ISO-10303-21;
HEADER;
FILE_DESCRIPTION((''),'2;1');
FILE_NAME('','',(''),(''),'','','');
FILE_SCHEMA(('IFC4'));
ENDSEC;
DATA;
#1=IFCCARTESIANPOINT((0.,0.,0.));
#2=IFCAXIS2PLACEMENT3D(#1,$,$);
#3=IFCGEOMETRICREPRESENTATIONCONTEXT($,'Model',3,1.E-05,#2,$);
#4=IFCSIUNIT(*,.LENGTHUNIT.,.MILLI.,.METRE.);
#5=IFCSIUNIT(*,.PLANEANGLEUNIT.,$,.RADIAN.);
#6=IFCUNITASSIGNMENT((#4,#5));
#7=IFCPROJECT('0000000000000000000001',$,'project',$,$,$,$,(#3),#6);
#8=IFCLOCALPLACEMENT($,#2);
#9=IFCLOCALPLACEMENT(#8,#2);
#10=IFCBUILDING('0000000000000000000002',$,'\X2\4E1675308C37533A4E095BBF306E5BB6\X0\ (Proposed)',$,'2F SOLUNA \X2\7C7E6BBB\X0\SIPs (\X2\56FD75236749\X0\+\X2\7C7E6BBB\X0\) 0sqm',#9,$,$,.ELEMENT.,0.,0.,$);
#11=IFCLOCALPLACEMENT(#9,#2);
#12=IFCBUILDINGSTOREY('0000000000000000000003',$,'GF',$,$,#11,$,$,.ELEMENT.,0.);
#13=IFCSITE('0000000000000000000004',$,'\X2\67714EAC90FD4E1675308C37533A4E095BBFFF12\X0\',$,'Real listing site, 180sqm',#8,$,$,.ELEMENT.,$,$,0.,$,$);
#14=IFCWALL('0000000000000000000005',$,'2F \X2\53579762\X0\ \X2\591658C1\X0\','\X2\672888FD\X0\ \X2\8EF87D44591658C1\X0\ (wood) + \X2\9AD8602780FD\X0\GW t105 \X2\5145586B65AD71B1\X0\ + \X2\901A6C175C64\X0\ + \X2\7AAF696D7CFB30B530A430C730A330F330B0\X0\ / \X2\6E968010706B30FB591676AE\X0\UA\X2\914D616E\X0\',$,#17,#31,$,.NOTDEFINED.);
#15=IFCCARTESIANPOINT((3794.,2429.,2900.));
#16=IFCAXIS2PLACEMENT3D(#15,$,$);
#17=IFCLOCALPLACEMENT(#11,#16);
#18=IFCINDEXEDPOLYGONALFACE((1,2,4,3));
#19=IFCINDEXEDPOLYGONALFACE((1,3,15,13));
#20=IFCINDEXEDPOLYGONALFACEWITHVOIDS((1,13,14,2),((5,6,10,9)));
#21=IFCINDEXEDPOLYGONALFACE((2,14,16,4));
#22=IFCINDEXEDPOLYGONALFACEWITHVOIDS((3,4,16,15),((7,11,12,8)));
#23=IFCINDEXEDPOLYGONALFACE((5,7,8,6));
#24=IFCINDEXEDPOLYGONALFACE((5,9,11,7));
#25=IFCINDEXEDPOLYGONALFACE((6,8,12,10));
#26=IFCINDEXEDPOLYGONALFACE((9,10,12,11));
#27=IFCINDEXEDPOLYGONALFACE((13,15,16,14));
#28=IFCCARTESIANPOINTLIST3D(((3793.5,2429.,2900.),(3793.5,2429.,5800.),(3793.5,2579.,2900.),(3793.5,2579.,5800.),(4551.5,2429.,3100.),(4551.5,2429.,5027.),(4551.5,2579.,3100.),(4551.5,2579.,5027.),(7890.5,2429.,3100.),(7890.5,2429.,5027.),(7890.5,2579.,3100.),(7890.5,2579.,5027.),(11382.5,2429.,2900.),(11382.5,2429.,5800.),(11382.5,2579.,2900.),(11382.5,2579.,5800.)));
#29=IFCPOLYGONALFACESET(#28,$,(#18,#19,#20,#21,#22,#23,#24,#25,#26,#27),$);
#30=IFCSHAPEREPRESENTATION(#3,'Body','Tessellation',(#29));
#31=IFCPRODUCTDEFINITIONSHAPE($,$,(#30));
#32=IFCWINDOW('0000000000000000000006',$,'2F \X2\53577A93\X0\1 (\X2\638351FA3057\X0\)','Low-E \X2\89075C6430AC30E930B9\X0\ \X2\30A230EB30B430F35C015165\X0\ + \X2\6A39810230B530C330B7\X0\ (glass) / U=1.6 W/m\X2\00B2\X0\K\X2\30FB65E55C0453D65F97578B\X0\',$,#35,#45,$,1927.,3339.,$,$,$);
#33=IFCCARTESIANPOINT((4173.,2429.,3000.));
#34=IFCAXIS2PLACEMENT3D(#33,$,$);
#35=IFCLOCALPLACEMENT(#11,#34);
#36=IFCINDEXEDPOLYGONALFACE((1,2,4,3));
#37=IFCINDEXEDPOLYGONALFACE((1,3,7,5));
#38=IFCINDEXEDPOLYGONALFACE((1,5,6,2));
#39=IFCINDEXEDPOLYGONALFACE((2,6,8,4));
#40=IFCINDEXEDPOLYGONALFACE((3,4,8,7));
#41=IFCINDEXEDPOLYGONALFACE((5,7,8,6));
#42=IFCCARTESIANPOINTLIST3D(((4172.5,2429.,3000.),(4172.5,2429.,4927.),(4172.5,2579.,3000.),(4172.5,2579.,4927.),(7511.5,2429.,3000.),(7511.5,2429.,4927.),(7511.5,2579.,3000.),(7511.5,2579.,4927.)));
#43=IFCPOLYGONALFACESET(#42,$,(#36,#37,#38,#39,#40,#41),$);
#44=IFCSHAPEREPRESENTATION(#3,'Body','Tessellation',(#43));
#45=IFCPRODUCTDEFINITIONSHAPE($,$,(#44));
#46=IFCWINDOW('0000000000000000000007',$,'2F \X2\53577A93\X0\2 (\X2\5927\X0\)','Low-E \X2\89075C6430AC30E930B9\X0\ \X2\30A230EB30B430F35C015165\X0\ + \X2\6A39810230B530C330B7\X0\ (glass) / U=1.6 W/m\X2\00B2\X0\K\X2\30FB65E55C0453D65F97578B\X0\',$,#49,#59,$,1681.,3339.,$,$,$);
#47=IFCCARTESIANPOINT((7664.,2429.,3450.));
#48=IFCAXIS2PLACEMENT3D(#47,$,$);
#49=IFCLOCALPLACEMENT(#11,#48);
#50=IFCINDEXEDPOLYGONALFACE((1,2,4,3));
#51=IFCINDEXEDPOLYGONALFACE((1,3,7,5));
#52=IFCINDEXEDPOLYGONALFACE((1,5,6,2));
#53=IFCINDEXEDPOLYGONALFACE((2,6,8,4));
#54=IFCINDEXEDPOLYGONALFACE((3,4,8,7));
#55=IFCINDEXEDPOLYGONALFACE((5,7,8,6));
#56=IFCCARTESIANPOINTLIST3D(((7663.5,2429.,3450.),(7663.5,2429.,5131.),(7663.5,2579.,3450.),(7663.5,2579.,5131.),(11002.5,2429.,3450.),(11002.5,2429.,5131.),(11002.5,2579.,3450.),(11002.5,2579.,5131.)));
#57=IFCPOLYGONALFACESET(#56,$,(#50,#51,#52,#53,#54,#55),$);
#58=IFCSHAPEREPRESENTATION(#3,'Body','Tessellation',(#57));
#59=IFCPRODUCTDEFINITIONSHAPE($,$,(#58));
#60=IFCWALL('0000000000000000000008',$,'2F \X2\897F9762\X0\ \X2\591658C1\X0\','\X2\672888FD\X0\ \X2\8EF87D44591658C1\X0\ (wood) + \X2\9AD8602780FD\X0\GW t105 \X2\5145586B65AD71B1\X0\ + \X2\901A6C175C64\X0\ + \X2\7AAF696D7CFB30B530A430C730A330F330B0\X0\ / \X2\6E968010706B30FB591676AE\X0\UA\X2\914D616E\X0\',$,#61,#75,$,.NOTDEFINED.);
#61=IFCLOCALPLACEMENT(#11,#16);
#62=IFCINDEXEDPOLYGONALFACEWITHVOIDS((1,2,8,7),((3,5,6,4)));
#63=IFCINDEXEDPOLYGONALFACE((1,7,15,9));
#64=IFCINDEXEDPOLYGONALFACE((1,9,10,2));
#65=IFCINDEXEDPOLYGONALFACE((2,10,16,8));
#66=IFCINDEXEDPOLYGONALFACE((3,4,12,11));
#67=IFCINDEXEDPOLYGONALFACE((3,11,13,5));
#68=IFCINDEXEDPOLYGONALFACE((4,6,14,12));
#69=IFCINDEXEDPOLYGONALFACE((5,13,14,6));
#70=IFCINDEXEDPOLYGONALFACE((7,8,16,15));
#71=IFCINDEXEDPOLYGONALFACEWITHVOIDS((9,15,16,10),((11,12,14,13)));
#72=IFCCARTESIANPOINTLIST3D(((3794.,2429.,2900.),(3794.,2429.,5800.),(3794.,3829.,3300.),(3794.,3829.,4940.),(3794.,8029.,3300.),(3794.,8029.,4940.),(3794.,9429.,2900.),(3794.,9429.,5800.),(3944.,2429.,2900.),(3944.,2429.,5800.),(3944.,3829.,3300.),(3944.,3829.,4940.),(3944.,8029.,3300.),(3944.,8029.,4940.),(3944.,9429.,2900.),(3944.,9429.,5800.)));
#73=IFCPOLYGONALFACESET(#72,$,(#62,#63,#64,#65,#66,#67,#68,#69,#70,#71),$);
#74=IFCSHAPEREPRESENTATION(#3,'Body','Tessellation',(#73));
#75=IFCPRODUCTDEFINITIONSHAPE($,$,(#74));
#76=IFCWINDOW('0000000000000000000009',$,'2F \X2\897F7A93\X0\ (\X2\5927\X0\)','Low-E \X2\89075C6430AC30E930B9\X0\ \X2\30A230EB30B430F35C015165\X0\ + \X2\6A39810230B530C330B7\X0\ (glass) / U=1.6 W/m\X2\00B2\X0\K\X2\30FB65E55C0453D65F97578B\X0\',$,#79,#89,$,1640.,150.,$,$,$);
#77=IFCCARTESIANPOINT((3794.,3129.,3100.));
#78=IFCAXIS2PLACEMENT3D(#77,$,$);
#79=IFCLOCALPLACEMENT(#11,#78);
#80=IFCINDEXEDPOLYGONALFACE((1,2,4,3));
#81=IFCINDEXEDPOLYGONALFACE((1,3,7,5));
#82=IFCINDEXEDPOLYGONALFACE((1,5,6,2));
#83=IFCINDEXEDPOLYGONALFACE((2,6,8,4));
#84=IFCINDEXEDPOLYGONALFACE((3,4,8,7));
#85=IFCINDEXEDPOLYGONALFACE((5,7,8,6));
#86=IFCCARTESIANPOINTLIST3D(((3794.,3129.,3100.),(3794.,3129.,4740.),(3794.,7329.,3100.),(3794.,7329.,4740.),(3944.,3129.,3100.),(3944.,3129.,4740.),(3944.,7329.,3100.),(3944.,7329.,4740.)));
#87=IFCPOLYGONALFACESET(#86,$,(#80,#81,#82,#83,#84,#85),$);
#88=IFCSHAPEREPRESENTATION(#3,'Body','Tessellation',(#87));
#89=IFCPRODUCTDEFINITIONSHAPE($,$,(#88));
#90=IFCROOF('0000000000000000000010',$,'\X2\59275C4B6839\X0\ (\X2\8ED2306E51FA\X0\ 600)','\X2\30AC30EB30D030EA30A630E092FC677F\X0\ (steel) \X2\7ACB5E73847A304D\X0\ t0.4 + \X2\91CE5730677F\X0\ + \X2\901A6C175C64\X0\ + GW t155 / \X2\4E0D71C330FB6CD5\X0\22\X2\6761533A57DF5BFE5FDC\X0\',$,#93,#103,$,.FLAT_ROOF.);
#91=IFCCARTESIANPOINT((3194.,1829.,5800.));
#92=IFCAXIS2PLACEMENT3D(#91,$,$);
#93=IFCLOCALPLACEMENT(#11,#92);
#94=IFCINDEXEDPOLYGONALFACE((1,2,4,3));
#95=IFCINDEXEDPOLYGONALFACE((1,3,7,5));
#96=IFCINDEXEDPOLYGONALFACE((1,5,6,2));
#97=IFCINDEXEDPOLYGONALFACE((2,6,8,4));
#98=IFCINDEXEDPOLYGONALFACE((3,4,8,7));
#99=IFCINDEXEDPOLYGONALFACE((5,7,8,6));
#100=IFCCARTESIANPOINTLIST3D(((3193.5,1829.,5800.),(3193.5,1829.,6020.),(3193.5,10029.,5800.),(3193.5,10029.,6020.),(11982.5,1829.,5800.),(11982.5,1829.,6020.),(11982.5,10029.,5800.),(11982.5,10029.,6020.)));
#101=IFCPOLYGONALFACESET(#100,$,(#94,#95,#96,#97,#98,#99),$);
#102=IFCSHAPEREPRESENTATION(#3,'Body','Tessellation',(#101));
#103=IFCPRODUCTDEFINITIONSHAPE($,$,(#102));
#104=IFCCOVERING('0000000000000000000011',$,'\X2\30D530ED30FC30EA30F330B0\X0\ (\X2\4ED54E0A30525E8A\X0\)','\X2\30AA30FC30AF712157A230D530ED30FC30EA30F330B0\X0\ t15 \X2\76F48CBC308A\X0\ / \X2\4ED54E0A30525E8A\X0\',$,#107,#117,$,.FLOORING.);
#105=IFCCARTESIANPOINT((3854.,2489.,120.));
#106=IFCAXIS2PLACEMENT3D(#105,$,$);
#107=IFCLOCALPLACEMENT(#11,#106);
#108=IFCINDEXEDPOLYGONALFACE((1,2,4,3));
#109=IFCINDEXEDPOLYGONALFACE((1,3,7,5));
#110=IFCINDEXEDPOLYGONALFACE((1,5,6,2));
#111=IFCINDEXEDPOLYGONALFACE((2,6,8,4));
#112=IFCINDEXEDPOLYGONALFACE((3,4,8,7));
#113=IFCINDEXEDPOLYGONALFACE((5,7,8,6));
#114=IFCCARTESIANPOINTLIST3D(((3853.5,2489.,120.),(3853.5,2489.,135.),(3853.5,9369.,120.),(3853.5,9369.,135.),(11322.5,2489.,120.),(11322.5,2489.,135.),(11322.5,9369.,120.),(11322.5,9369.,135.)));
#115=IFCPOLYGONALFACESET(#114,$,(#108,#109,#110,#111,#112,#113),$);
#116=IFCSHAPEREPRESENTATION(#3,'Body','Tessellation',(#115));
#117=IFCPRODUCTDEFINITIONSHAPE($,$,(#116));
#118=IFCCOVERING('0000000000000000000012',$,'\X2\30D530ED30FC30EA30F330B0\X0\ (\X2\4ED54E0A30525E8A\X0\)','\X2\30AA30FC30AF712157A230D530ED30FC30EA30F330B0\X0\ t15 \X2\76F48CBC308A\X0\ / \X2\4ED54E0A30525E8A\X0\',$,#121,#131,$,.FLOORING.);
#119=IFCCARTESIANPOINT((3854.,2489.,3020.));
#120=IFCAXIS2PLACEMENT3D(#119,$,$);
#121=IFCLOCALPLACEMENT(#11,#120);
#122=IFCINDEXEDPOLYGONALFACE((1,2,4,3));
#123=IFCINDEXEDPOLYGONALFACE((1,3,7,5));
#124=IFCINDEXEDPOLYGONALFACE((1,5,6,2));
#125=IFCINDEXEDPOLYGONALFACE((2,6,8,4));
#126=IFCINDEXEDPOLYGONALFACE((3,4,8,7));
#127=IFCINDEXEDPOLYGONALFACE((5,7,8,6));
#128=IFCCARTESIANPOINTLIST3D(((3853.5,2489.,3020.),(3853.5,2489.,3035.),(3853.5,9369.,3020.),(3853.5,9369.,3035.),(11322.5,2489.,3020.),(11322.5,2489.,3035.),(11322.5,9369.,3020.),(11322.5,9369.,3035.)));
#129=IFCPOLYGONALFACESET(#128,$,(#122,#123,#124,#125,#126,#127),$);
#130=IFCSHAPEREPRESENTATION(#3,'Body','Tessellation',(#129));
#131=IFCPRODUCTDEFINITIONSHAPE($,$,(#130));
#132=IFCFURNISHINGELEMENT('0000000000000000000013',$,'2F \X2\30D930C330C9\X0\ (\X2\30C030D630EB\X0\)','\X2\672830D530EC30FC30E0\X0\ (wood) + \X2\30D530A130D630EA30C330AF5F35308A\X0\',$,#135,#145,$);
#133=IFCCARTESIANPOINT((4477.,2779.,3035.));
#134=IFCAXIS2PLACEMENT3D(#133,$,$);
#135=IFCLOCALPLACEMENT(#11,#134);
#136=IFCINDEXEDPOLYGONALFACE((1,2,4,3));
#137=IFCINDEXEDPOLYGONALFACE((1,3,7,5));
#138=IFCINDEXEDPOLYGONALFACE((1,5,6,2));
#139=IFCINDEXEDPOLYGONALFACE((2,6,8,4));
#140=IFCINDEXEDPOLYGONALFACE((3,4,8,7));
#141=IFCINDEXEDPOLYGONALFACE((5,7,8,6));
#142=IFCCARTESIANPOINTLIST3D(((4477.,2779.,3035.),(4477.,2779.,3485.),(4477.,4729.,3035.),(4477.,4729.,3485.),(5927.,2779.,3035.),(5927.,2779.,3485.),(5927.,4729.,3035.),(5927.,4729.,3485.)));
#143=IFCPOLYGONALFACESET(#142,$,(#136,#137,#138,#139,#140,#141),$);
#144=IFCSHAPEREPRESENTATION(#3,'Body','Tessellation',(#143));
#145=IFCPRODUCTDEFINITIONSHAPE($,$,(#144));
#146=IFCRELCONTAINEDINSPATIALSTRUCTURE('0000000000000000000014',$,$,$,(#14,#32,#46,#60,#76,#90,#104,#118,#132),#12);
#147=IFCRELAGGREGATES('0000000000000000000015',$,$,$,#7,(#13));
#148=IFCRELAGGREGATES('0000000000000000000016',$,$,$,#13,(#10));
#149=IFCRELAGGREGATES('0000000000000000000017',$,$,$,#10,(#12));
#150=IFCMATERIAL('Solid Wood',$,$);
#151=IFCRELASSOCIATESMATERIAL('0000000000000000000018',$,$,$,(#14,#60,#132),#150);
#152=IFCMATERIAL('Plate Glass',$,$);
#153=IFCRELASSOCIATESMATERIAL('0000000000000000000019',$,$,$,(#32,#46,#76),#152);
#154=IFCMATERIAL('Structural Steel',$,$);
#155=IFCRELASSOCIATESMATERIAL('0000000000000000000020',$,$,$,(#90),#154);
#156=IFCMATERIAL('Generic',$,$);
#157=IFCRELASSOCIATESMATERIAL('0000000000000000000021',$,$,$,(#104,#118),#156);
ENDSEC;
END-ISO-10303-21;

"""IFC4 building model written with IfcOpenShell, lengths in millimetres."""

from ifc_helpers import new_model, si_unit, frame, frame_2d, origin, place, context, project, spatial, rectangle, extrude, material, element, fill, save


model = new_model("IFC4")

# Units and contexts
model_context = context("Model", 3, precision=1e-05, world=origin())
ifc_project = project(units=[si_unit("LENGTHUNIT", "METRE", prefix="MILLI"), si_unit("PLANEANGLEUNIT", "RADIAN")], contexts=[model_context])

# Site, building, storey
site_placement = place(None, origin())
site = spatial("IfcSite", under=ifc_project, at=site_placement, Name="東京都世田谷区三宿２", ObjectType="Real listing site, 180sqm", CompositionType="ELEMENT", RefElevation=0.0)
building_placement = place(site_placement, origin())
building = spatial("IfcBuilding", under=site, at=building_placement, Name="世田谷区三宿の家 (Proposed)", ObjectType="2F SOLUNA 籾殻SIPs (国産杉+籾殻) 0sqm", CompositionType="ELEMENT", ElevationOfRefHeight=0.0, ElevationOfTerrain=0.0)
storey_placement = place(building_placement, origin())
storey = spatial("IfcBuildingStorey", under=building, at=storey_placement, Name="GF", CompositionType="ELEMENT", Elevation=0.0)

# Shared definitions
ifc_material_1 = material(Name="Solid Wood")

# Shared definitions
ifc_material_2 = material(Name="Plate Glass")

# Wall, openings, windows
wall_1_placement = place(storey_placement, frame((3794.0, 2429.0, 2900.0)))
wall_1 = element("IfcWall", 1, at=wall_1_placement, inside=storey, material=ifc_material_1, Name="2F 南面 外壁", Description="木製 軸組外壁 (wood) + 高性能GW t105 充填断熱 + 通気層 + 窯業系サイディング / 準耐火・外皮UA配慮", PredefinedType="NOTDEFINED", context=model_context, shape_type="SweptSolid", body=[
    extrude(rectangle(XDim=7589.0, YDim=150.0, at=frame_2d((3794.0, 75.0))), frame((3794.0, 2429.0, 2900.0)), (0.0, 0.0, 1.0), 2900.0),
])
opening_1_placement = place(storey_placement, frame((4173.0, 2429.0, 3000.0)))
opening_1 = element("IfcOpeningElement", 2, at=opening_1_placement, cuts=wall_1, PredefinedType="NOTDEFINED", context=model_context, shape_type="SweptSolid", body=[
    extrude(rectangle(XDim=3339.0, YDim=150.0, at=frame_2d((1669.0, 75.0))), frame((4173.0, 2429.0, 3000.0)), (0.0, 0.0, 1.0), 1927.0),
])
opening_2_placement = place(storey_placement, frame((7664.0, 2429.0, 3450.0)))
opening_2 = element("IfcOpeningElement", 3, at=opening_2_placement, cuts=wall_1, PredefinedType="NOTDEFINED", context=model_context, shape_type="SweptSolid", body=[
    extrude(rectangle(XDim=3339.0, YDim=150.0, at=frame_2d((1669.0, 75.0))), frame((7664.0, 2429.0, 3450.0)), (0.0, 0.0, 1.0), 1681.0),
])
window_1_placement = place(storey_placement, frame((4173.0, 2429.0, 3000.0)))
window_1 = element("IfcWindow", 4, at=window_1_placement, inside=storey, material=ifc_material_2, Name="2F 南窓1 (掃出し)", Description="Low-E 複層ガラス アルゴン封入 + 樹脂サッシ (glass) / U=1.6 W/m²K・日射取得型", OverallHeight=1927.0, OverallWidth=3339.0, context=model_context, shape_type="SweptSolid", body=[
    extrude(rectangle(XDim=3339.0, YDim=150.0, at=frame_2d((1669.0, 75.0))), frame((4173.0, 2429.0, 3000.0)), (0.0, 0.0, 1.0), 1927.0),
])
fill(opening_1, window_1)
window_2_placement = place(storey_placement, frame((7664.0, 2429.0, 3450.0)))
window_2 = element("IfcWindow", 5, at=window_2_placement, inside=storey, material=ifc_material_2, Name="2F 南窓2 (大)", Description="Low-E 複層ガラス アルゴン封入 + 樹脂サッシ (glass) / U=1.6 W/m²K・日射取得型", OverallHeight=1681.0, OverallWidth=3339.0, context=model_context, shape_type="SweptSolid", body=[
    extrude(rectangle(XDim=3339.0, YDim=150.0, at=frame_2d((1669.0, 75.0))), frame((7664.0, 2429.0, 3450.0)), (0.0, 0.0, 1.0), 1681.0),
])
fill(opening_2, window_2)

# Wall, opening, window
wall_2_placement = place(storey_placement, frame((3794.0, 2429.0, 2900.0)))
wall_2 = element("IfcWall", 6, at=wall_2_placement, inside=storey, material=ifc_material_1, Name="2F 西面 外壁", Description="木製 軸組外壁 (wood) + 高性能GW t105 充填断熱 + 通気層 + 窯業系サイディング / 準耐火・外皮UA配慮", PredefinedType="NOTDEFINED", context=model_context, shape_type="SweptSolid", body=[
    extrude(rectangle(XDim=150.0, YDim=7000.0, at=frame_2d((75.0, 3500.0))), frame((3794.0, 2429.0, 2900.0)), (0.0, 0.0, 1.0), 2900.0),
])
opening_3_placement = place(storey_placement, frame((3794.0, 3129.0, 3100.0)))
opening_3 = element("IfcOpeningElement", 7, at=opening_3_placement, cuts=wall_2, PredefinedType="NOTDEFINED", context=model_context, shape_type="SweptSolid", body=[
    extrude(rectangle(XDim=150.0, YDim=4200.0, at=frame_2d((75.0, 2100.0))), frame((3794.0, 3129.0, 3100.0)), (0.0, 0.0, 1.0), 1640.0),
])
window_3_placement = place(storey_placement, frame((3794.0, 3129.0, 3100.0)))
window_3 = element("IfcWindow", 8, at=window_3_placement, inside=storey, material=ifc_material_2, Name="2F 西窓 (大)", Description="Low-E 複層ガラス アルゴン封入 + 樹脂サッシ (glass) / U=1.6 W/m²K・日射取得型", OverallHeight=1640.0, OverallWidth=150.0, context=model_context, shape_type="SweptSolid", body=[
    extrude(rectangle(XDim=150.0, YDim=4200.0, at=frame_2d((75.0, 2100.0))), frame((3794.0, 3129.0, 3100.0)), (0.0, 0.0, 1.0), 1640.0),
])
fill(opening_3, window_3)

# Roof
ifc_material_3 = material(Name="Structural Steel")
roof_placement = place(storey_placement, frame((3194.0, 1829.0, 5800.0)))
element("IfcRoof", 9, at=roof_placement, inside=storey, material=ifc_material_3, Name="大屋根 (軒の出 600)", Description="ガルバリウム鋼板 (steel) 立平葺き t0.4 + 野地板 + 通気層 + GW t155 / 不燃・法22条区域対応", PredefinedType="FLAT_ROOF", context=model_context, shape_type="SweptSolid", body=[
    extrude(rectangle(XDim=8789.0, YDim=8200.0, at=frame_2d((4394.0, 4100.0))), frame((3194.0, 1829.0, 5800.0)), (0.0, 0.0, 1.0), 220.0),
])

# Coverings
ifc_material_4 = material(Name="Generic")
covering_1_placement = place(storey_placement, frame((3854.0, 2489.0, 120.0)))
element("IfcCovering", 10, at=covering_1_placement, inside=storey, material=ifc_material_4, Name="フローリング (仕上げ床)", Description="オーク無垢フローリング t15 直貼り / 仕上げ床", PredefinedType="FLOORING", context=model_context, shape_type="SweptSolid", body=[
    extrude(rectangle(XDim=7469.0, YDim=6880.0, at=frame_2d((3734.0, 3440.0))), frame((3854.0, 2489.0, 120.0)), (0.0, 0.0, 1.0), 15.0),
])
covering_2_placement = place(storey_placement, frame((3854.0, 2489.0, 3020.0)))
element("IfcCovering", 11, at=covering_2_placement, inside=storey, material=ifc_material_4, Name="フローリング (仕上げ床)", Description="オーク無垢フローリング t15 直貼り / 仕上げ床", PredefinedType="FLOORING", context=model_context, shape_type="SweptSolid", body=[
    extrude(rectangle(XDim=7469.0, YDim=6880.0, at=frame_2d((3734.0, 3440.0))), frame((3854.0, 2489.0, 3020.0)), (0.0, 0.0, 1.0), 15.0),
])

# Furnishing element
furnishing_placement = place(storey_placement, frame((4477.0, 2779.0, 3035.0)))
element("IfcFurnishingElement", 12, at=furnishing_placement, inside=storey, material=ifc_material_1, Name="2F ベッド (ダブル)", Description="木フレーム (wood) + ファブリック張り", context=model_context, shape_type="SweptSolid", body=[
    extrude(rectangle(XDim=1450.0, YDim=1950.0, at=frame_2d((725.0, 975.0))), frame((4477.0, 2779.0, 3035.0)), (0.0, 0.0, 1.0), 450.0),
])

save(model, "model.ifc")
